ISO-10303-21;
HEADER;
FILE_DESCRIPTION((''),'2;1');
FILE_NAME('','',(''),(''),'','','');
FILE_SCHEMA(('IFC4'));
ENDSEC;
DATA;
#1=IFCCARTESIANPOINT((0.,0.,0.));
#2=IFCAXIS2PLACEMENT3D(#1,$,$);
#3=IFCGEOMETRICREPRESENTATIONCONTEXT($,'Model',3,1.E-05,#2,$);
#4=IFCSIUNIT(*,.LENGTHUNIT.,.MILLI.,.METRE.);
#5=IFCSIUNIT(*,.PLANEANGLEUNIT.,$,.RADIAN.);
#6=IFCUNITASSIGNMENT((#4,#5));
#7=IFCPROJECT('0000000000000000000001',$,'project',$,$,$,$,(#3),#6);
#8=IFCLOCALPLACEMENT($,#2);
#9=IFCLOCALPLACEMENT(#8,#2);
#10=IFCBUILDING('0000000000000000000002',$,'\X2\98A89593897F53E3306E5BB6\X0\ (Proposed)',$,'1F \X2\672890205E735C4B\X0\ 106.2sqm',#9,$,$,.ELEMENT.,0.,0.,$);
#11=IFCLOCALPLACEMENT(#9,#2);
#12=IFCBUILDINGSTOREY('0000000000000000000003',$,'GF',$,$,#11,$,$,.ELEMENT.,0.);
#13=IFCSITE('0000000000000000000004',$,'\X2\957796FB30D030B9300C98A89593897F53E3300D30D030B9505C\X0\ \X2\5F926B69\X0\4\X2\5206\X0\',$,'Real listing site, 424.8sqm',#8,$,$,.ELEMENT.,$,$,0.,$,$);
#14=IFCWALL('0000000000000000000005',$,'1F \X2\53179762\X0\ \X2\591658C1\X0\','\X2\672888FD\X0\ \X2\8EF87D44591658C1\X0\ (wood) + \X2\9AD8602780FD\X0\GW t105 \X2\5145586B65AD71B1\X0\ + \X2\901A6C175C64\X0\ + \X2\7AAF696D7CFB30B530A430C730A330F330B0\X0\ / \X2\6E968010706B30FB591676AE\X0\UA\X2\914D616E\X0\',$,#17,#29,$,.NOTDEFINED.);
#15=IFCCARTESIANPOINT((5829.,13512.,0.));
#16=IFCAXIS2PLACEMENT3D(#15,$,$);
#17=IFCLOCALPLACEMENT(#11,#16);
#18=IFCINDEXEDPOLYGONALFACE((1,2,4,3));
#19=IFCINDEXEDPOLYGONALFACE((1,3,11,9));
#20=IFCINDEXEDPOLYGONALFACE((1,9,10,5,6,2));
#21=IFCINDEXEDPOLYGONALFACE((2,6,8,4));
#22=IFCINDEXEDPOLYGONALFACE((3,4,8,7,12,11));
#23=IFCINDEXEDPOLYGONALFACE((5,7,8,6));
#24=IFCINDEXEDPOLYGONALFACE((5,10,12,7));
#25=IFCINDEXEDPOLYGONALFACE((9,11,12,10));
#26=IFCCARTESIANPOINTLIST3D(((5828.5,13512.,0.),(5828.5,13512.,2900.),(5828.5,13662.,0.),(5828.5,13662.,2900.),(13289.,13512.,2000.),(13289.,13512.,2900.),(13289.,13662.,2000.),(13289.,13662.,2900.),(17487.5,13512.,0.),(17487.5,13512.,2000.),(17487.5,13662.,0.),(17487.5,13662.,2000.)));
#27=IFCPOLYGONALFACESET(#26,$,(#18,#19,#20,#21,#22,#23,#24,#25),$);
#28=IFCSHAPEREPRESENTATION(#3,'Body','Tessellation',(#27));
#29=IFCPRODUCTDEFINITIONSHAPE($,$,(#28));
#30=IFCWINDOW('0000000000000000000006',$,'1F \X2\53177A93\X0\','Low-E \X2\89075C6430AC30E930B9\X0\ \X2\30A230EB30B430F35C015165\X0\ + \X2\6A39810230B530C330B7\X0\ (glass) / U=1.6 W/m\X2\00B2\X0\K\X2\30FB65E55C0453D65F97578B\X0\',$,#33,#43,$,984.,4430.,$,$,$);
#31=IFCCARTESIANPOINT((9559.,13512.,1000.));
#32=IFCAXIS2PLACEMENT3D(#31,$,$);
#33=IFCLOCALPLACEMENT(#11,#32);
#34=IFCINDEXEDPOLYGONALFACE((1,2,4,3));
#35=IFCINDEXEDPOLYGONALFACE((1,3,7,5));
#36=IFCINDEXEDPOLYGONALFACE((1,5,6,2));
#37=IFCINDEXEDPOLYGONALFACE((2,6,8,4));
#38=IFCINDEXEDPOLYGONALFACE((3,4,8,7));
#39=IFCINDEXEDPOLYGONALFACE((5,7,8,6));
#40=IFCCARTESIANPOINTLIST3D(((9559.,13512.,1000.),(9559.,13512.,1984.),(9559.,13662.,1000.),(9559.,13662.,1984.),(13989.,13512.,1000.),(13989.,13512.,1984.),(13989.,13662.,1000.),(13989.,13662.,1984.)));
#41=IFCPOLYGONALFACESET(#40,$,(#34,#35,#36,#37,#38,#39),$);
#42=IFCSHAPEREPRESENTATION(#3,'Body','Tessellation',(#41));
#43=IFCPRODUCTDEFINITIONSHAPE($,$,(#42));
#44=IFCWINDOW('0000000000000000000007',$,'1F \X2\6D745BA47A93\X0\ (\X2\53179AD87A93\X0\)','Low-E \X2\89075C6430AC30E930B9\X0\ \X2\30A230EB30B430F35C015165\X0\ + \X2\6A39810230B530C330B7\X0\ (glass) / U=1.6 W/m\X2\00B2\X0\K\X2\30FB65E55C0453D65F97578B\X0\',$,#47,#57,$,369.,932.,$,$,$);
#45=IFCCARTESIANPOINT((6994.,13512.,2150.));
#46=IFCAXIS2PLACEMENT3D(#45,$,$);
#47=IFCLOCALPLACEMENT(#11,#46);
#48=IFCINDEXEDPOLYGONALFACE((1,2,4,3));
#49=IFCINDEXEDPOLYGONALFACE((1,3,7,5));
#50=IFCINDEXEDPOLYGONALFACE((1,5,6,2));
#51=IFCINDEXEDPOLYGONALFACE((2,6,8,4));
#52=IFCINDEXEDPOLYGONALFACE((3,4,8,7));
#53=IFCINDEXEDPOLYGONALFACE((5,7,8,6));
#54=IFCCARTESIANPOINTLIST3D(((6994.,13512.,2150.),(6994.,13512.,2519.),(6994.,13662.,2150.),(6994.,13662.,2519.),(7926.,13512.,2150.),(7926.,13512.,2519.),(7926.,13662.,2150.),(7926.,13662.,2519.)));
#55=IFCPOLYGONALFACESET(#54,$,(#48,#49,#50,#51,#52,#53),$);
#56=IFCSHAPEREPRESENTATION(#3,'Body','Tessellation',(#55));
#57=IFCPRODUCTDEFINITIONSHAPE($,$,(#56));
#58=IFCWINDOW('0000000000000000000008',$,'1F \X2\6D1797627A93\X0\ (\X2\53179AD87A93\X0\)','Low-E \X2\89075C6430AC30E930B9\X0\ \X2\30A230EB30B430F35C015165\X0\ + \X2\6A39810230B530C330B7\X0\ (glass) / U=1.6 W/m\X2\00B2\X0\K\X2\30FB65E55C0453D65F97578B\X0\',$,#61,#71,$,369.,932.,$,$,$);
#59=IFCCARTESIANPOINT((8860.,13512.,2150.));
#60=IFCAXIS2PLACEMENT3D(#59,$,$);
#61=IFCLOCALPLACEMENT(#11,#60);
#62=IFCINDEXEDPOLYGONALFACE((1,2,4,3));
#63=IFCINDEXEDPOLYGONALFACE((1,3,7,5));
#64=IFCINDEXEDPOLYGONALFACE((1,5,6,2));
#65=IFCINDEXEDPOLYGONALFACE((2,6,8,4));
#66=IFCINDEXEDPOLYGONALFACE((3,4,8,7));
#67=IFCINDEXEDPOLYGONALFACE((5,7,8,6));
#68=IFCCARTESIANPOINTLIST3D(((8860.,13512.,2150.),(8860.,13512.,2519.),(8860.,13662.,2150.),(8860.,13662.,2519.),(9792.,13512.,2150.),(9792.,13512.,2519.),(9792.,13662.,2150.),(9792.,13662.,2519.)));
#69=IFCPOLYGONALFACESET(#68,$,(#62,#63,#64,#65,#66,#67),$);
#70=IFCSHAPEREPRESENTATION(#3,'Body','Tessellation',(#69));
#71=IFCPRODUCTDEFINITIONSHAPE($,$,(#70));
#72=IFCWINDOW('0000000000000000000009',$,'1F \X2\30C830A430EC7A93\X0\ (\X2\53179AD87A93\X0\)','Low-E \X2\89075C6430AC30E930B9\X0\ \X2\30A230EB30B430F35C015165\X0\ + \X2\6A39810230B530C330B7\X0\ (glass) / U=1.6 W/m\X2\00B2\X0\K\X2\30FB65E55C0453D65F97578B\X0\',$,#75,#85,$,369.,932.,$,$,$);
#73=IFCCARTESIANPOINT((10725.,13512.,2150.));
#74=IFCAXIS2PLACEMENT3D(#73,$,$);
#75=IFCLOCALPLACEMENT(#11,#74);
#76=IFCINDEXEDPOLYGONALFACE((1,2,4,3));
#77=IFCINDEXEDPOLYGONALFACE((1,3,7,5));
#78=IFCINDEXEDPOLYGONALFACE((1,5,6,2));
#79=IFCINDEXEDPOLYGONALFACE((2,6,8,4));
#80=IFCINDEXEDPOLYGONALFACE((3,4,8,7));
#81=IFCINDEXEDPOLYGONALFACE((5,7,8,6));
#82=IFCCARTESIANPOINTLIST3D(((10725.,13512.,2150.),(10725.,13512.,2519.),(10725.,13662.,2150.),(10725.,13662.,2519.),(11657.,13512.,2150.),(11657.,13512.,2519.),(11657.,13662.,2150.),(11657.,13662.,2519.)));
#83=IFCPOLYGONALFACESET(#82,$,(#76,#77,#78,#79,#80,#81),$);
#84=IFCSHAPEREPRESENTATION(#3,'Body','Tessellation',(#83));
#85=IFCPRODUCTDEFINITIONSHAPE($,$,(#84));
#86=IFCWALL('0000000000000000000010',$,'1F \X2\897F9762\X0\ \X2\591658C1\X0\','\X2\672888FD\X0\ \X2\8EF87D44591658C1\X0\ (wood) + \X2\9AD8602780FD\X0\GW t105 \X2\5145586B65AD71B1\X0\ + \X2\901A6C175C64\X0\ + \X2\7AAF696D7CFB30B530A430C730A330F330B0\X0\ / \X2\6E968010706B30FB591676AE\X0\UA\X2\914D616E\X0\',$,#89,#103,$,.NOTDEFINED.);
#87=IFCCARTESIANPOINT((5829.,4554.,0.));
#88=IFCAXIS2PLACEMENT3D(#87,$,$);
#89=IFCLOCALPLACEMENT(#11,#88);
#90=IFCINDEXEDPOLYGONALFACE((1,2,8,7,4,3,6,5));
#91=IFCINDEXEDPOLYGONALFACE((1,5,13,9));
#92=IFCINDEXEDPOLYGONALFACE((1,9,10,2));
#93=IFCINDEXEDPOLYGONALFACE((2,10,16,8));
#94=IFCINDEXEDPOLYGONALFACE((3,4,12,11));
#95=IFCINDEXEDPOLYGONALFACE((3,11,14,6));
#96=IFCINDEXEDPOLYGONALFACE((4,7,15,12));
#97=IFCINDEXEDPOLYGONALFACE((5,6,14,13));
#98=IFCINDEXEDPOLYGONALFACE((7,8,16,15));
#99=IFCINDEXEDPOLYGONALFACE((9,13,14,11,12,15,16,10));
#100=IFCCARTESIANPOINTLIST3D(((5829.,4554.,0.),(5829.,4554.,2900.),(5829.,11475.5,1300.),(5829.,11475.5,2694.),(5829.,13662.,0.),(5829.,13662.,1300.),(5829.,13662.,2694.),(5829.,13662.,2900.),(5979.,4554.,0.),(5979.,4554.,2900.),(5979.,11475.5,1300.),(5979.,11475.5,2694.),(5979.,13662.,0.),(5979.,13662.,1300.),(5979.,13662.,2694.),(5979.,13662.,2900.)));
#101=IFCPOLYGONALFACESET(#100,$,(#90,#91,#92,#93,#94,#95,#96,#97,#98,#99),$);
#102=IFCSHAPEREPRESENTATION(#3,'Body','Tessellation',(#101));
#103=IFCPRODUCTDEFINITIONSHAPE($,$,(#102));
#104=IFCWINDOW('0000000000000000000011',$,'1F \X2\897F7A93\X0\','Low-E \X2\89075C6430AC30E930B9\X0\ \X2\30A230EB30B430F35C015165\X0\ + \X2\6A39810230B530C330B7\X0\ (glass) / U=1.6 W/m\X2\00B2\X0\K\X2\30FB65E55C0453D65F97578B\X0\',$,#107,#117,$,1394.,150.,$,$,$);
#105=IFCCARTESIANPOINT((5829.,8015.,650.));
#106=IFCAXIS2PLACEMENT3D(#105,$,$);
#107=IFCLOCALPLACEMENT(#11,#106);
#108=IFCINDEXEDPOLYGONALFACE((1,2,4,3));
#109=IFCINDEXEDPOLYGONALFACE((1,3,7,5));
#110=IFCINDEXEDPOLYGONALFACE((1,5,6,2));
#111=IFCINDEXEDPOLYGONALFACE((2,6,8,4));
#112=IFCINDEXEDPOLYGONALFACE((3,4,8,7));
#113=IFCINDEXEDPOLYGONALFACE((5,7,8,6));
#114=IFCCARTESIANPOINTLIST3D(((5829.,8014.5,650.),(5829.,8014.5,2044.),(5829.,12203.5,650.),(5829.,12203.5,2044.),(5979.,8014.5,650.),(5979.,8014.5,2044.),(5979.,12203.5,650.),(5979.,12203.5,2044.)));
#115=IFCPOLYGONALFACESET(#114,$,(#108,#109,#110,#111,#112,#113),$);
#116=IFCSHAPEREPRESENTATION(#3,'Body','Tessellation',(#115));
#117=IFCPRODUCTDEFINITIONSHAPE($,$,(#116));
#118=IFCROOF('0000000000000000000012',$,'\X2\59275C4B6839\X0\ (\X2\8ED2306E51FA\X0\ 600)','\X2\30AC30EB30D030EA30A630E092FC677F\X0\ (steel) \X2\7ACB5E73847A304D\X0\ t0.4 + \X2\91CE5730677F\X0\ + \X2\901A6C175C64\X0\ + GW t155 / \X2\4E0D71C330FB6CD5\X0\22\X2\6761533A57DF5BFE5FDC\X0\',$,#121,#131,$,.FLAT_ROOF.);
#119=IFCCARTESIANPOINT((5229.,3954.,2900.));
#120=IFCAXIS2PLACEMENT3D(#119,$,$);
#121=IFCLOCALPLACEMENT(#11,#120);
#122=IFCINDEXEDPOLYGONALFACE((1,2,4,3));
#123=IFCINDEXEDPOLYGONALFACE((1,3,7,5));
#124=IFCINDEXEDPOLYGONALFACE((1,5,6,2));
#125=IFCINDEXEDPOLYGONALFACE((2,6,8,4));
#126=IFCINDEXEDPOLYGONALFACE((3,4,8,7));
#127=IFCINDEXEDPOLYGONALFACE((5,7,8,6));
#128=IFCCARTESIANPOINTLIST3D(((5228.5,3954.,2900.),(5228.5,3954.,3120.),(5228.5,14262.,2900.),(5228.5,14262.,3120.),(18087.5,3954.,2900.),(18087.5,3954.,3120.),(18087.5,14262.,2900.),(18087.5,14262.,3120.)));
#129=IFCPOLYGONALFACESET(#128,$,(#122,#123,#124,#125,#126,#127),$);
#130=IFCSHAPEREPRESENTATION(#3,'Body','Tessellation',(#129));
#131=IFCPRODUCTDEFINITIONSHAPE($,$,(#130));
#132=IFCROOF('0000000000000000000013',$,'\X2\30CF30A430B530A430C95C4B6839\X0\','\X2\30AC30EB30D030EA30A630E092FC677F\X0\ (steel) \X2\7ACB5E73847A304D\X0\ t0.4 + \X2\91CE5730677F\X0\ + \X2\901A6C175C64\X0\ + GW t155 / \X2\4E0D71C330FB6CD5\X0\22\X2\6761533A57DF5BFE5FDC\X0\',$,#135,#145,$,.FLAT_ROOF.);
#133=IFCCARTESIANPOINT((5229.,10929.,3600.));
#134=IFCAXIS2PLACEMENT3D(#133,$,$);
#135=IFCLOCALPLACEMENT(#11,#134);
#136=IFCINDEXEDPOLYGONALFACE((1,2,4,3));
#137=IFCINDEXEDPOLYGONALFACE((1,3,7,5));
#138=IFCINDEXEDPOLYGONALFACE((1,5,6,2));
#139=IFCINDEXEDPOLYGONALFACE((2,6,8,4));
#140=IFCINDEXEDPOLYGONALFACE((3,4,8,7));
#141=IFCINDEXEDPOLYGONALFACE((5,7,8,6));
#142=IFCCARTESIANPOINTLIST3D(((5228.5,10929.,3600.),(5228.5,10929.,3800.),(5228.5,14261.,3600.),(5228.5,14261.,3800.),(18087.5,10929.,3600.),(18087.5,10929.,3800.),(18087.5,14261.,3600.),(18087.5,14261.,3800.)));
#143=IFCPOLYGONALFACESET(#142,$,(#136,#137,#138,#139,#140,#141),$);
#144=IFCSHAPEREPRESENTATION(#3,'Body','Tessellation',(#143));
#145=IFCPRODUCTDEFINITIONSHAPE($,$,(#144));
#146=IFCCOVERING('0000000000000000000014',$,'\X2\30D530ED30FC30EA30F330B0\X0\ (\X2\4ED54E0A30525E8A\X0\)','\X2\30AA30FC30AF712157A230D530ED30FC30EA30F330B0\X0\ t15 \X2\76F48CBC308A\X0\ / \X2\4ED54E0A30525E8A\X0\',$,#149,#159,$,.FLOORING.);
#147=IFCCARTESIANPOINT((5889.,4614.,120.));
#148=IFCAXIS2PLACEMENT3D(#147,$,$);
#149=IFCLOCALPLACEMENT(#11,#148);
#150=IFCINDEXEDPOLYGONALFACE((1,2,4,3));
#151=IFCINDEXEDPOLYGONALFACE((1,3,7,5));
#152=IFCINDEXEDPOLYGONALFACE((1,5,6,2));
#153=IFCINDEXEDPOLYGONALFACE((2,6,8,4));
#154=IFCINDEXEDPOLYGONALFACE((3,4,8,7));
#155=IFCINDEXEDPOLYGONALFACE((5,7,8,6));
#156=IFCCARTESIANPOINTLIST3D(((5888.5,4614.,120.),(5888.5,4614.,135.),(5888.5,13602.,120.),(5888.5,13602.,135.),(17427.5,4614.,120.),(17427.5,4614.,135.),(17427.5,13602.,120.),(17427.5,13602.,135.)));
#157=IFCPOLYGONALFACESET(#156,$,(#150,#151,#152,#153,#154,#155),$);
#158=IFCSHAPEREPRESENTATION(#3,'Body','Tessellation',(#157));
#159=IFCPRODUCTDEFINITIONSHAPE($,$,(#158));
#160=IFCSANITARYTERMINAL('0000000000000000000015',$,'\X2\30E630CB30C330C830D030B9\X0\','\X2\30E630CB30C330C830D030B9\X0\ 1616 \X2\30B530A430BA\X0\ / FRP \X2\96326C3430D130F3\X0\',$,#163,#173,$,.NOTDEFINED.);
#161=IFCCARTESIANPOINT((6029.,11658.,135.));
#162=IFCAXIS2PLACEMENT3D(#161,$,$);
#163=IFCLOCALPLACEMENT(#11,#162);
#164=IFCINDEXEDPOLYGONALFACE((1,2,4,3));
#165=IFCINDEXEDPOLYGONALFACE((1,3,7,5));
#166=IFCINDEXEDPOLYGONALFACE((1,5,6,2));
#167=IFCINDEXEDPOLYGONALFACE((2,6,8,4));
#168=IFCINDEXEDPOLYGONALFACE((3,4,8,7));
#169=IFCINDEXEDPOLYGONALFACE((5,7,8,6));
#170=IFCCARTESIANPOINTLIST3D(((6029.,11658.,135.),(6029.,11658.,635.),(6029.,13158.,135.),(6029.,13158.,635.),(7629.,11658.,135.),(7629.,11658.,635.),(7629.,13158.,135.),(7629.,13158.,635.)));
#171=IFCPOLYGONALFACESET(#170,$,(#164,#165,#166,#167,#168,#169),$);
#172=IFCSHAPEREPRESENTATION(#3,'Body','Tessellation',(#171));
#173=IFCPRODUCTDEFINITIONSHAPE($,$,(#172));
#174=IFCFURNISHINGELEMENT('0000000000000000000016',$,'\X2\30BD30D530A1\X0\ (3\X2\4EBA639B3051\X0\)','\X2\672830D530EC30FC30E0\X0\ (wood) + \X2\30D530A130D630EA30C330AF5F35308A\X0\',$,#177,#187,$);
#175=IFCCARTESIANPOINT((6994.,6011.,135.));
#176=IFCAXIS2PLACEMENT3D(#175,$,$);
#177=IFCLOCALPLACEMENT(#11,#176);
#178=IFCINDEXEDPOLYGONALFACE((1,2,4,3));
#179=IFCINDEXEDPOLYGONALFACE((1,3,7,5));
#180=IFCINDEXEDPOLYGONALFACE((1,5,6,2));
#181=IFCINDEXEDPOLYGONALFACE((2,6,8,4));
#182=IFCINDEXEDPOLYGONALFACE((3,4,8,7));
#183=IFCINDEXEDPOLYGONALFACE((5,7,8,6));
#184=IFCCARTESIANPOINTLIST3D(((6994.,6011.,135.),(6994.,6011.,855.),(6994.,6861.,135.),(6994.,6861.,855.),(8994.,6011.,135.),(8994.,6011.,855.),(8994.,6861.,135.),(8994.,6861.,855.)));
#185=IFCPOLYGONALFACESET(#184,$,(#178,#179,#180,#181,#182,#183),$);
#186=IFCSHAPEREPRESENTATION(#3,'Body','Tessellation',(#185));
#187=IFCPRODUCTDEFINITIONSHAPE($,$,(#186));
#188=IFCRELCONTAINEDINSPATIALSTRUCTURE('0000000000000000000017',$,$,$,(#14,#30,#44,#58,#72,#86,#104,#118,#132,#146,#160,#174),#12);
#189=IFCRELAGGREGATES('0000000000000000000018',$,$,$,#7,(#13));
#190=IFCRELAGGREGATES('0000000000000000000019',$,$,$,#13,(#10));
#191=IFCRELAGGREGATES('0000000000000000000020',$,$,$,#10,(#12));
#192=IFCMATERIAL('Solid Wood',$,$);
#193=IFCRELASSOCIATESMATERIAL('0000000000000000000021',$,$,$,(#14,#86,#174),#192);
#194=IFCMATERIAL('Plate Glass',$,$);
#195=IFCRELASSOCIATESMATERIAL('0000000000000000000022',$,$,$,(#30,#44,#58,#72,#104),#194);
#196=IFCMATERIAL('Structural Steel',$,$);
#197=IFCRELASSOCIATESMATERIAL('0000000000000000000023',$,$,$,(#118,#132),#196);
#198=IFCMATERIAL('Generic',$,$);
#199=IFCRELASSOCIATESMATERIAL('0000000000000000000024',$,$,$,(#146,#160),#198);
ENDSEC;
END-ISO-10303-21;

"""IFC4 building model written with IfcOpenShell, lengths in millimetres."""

from ifc_helpers import new_model, si_unit, frame, frame_2d, origin, place, context, project, spatial, rectangle, extrude, material, element, fill, save


model = new_model("IFC4")

# Units and contexts
model_context = context("Model", 3, precision=1e-05, world=origin())
ifc_project = project(units=[si_unit("LENGTHUNIT", "METRE", prefix="MILLI"), si_unit("PLANEANGLEUNIT", "RADIAN")], contexts=[model_context])

# Site, building, storey
site_placement = place(None, origin())
site = spatial("IfcSite", under=ifc_project, at=site_placement, Name="長電バス「風間西口」バス停 徒歩4分", ObjectType="Real listing site, 424.8sqm", CompositionType="ELEMENT", RefElevation=0.0)
building_placement = place(site_placement, origin())
building = spatial("IfcBuilding", under=site, at=building_placement, Name="風間西口の家 (Proposed)", ObjectType="1F 木造平屋 106.2sqm", CompositionType="ELEMENT", ElevationOfRefHeight=0.0, ElevationOfTerrain=0.0)
storey_placement = place(building_placement, origin())
storey = spatial("IfcBuildingStorey", under=building, at=storey_placement, Name="GF", CompositionType="ELEMENT", Elevation=0.0)

# Shared definitions
ifc_material_1 = material(Name="Solid Wood")

# Shared definitions
ifc_material_2 = material(Name="Plate Glass")

# Wall, openings, windows
wall_1_placement = place(storey_placement, frame((5829.0, 13512.0, 0.0)))
wall_1 = element("IfcWall", 1, at=wall_1_placement, inside=storey, material=ifc_material_1, Name="1F 北面 外壁", Description="木製 軸組外壁 (wood) + 高性能GW t105 充填断熱 + 通気層 + 窯業系サイディング / 準耐火・外皮UA配慮", PredefinedType="NOTDEFINED", context=model_context, shape_type="SweptSolid", body=[
    extrude(rectangle(XDim=11659.0, YDim=150.0, at=frame_2d((5829.0, 75.0))), frame((5829.0, 13512.0, 0.0)), (0.0, 0.0, 1.0), 2900.0),
])
opening_1_placement = place(storey_placement, frame((9559.0, 13512.0, 1000.0)))
opening_1 = element("IfcOpeningElement", 2, at=opening_1_placement, cuts=wall_1, PredefinedType="NOTDEFINED", context=model_context, shape_type="SweptSolid", body=[
    extrude(rectangle(XDim=4430.0, YDim=150.0, at=frame_2d((2215.0, 75.0))), frame((9559.0, 13512.0, 1000.0)), (0.0, 0.0, 1.0), 984.0),
])
opening_2_placement = place(storey_placement, frame((6994.0, 13512.0, 2150.0)))
opening_2 = element("IfcOpeningElement", 3, at=opening_2_placement, cuts=wall_1, PredefinedType="NOTDEFINED", context=model_context, shape_type="SweptSolid", body=[
    extrude(rectangle(XDim=932.0, YDim=150.0, at=frame_2d((466.0, 75.0))), frame((6994.0, 13512.0, 2150.0)), (0.0, 0.0, 1.0), 369.0),
])
opening_3_placement = place(storey_placement, frame((8860.0, 13512.0, 2150.0)))
opening_3 = element("IfcOpeningElement", 4, at=opening_3_placement, cuts=wall_1, PredefinedType="NOTDEFINED", context=model_context, shape_type="SweptSolid", body=[
    extrude(rectangle(XDim=932.0, YDim=150.0, at=frame_2d((466.0, 75.0))), frame((8860.0, 13512.0, 2150.0)), (0.0, 0.0, 1.0), 369.0),
])
opening_4_placement = place(storey_placement, frame((10725.0, 13512.0, 2150.0)))
opening_4 = element("IfcOpeningElement", 5, at=opening_4_placement, cuts=wall_1, PredefinedType="NOTDEFINED", context=model_context, shape_type="SweptSolid", body=[
    extrude(rectangle(XDim=932.0, YDim=150.0, at=frame_2d((466.0, 75.0))), frame((10725.0, 13512.0, 2150.0)), (0.0, 0.0, 1.0), 369.0),
])
window_1_placement = place(storey_placement, frame((9559.0, 13512.0, 1000.0)))
window_1 = element("IfcWindow", 6, at=window_1_placement, inside=storey, material=ifc_material_2, Name="1F 北窓", Description="Low-E 複層ガラス アルゴン封入 + 樹脂サッシ (glass) / U=1.6 W/m²K・日射取得型", OverallHeight=984.0, OverallWidth=4430.0, context=model_context, shape_type="SweptSolid", body=[
    extrude(rectangle(XDim=4430.0, YDim=150.0, at=frame_2d((2215.0, 75.0))), frame((9559.0, 13512.0, 1000.0)), (0.0, 0.0, 1.0), 984.0),
])
fill(opening_1, window_1)
window_2_placement = place(storey_placement, frame((6994.0, 13512.0, 2150.0)))
window_2 = element("IfcWindow", 7, at=window_2_placement, inside=storey, material=ifc_material_2, Name="1F 浴室窓 (北高窓)", Description="Low-E 複層ガラス アルゴン封入 + 樹脂サッシ (glass) / U=1.6 W/m²K・日射取得型", OverallHeight=369.0, OverallWidth=932.0, context=model_context, shape_type="SweptSolid", body=[
    extrude(rectangle(XDim=932.0, YDim=150.0, at=frame_2d((466.0, 75.0))), frame((6994.0, 13512.0, 2150.0)), (0.0, 0.0, 1.0), 369.0),
])
fill(opening_2, window_2)
window_3_placement = place(storey_placement, frame((8860.0, 13512.0, 2150.0)))
window_3 = element("IfcWindow", 8, at=window_3_placement, inside=storey, material=ifc_material_2, Name="1F 洗面窓 (北高窓)", Description="Low-E 複層ガラス アルゴン封入 + 樹脂サッシ (glass) / U=1.6 W/m²K・日射取得型", OverallHeight=369.0, OverallWidth=932.0, context=model_context, shape_type="SweptSolid", body=[
    extrude(rectangle(XDim=932.0, YDim=150.0, at=frame_2d((466.0, 75.0))), frame((8860.0, 13512.0, 2150.0)), (0.0, 0.0, 1.0), 369.0),
])
fill(opening_3, window_3)
window_4_placement = place(storey_placement, frame((10725.0, 13512.0, 2150.0)))
window_4 = element("IfcWindow", 9, at=window_4_placement, inside=storey, material=ifc_material_2, Name="1F トイレ窓 (北高窓)", Description="Low-E 複層ガラス アルゴン封入 + 樹脂サッシ (glass) / U=1.6 W/m²K・日射取得型", OverallHeight=369.0, OverallWidth=932.0, context=model_context, shape_type="SweptSolid", body=[
    extrude(rectangle(XDim=932.0, YDim=150.0, at=frame_2d((466.0, 75.0))), frame((10725.0, 13512.0, 2150.0)), (0.0, 0.0, 1.0), 369.0),
])
fill(opening_4, window_4)

# Wall, opening, window
wall_2_placement = place(storey_placement, frame((5829.0, 4554.0, 0.0)))
wall_2 = element("IfcWall", 10, at=wall_2_placement, inside=storey, material=ifc_material_1, Name="1F 西面 外壁", Description="木製 軸組外壁 (wood) + 高性能GW t105 充填断熱 + 通気層 + 窯業系サイディング / 準耐火・外皮UA配慮", PredefinedType="NOTDEFINED", context=model_context, shape_type="SweptSolid", body=[
    extrude(rectangle(XDim=150.0, YDim=9108.0, at=frame_2d((75.0, 4554.0))), frame((5829.0, 4554.0, 0.0)), (0.0, 0.0, 1.0), 2900.0),
])
opening_5_placement = place(storey_placement, frame((5829.0, 8015.0, 650.0)))
opening_5 = element("IfcOpeningElement", 11, at=opening_5_placement, cuts=wall_2, PredefinedType="NOTDEFINED", context=model_context, shape_type="SweptSolid", body=[
    extrude(rectangle(XDim=150.0, YDim=4189.0, at=frame_2d((75.0, 2094.0))), frame((5829.0, 8015.0, 650.0)), (0.0, 0.0, 1.0), 1394.0),
])
window_5_placement = place(storey_placement, frame((5829.0, 8015.0, 650.0)))
window_5 = element("IfcWindow", 12, at=window_5_placement, inside=storey, material=ifc_material_2, Name="1F 西窓", Description="Low-E 複層ガラス アルゴン封入 + 樹脂サッシ (glass) / U=1.6 W/m²K・日射取得型", OverallHeight=1394.0, OverallWidth=150.0, context=model_context, shape_type="SweptSolid", body=[
    extrude(rectangle(XDim=150.0, YDim=4189.0, at=frame_2d((75.0, 2094.0))), frame((5829.0, 8015.0, 650.0)), (0.0, 0.0, 1.0), 1394.0),
])
fill(opening_5, window_5)

# Roofs
ifc_material_3 = material(Name="Structural Steel")
roof_1_placement = place(storey_placement, frame((5229.0, 3954.0, 2900.0)))
element("IfcRoof", 13, at=roof_1_placement, inside=storey, material=ifc_material_3, Name="大屋根 (軒の出 600)", Description="ガルバリウム鋼板 (steel) 立平葺き t0.4 + 野地板 + 通気層 + GW t155 / 不燃・法22条区域対応", PredefinedType="FLAT_ROOF", context=model_context, shape_type="SweptSolid", body=[
    extrude(rectangle(XDim=12859.0, YDim=10308.0, at=frame_2d((6429.0, 5154.0))), frame((5229.0, 3954.0, 2900.0)), (0.0, 0.0, 1.0), 220.0),
])
roof_2_placement = place(storey_placement, frame((5229.0, 10929.0, 3600.0)))
element("IfcRoof", 14, at=roof_2_placement, inside=storey, material=ifc_material_3, Name="ハイサイド屋根", Description="ガルバリウム鋼板 (steel) 立平葺き t0.4 + 野地板 + 通気層 + GW t155 / 不燃・法22条区域対応", PredefinedType="FLAT_ROOF", context=model_context, shape_type="SweptSolid", body=[
    extrude(rectangle(XDim=12859.0, YDim=3332.0, at=frame_2d((6429.0, 1666.0))), frame((5229.0, 10929.0, 3600.0)), (0.0, 0.0, 1.0), 200.0),
])

# Covering
ifc_material_4 = material(Name="Generic")
covering_placement = place(storey_placement, frame((5889.0, 4614.0, 120.0)))
element("IfcCovering", 15, at=covering_placement, inside=storey, material=ifc_material_4, Name="フローリング (仕上げ床)", Description="オーク無垢フローリング t15 直貼り / 仕上げ床", PredefinedType="FLOORING", context=model_context, shape_type="SweptSolid", body=[
    extrude(rectangle(XDim=11539.0, YDim=8988.0, at=frame_2d((5769.0, 4494.0))), frame((5889.0, 4614.0, 120.0)), (0.0, 0.0, 1.0), 15.0),
])

# Sanitary terminal
sanitary_terminal_placement = place(storey_placement, frame((6029.0, 11658.0, 135.0)))
element("IfcSanitaryTerminal", 16, at=sanitary_terminal_placement, inside=storey, material=ifc_material_4, Name="ユニットバス", Description="ユニットバス 1616 サイズ / FRP 防水パン", PredefinedType="NOTDEFINED", context=model_context, shape_type="SweptSolid", body=[
    extrude(rectangle(XDim=1600.0, YDim=1500.0, at=frame_2d((800.0, 750.0))), frame((6029.0, 11658.0, 135.0)), (0.0, 0.0, 1.0), 500.0),
])

# Furnishing element
furnishing_1_placement = place(storey_placement, frame((6994.0, 6011.0, 135.0)))
element("IfcFurnishingElement", 17, at=furnishing_1_placement, inside=storey, material=ifc_material_1, Name="ソファ (3人掛け)", Description="木フレーム (wood) + ファブリック張り", context=model_context, shape_type="SweptSolid", body=[
    extrude(rectangle(XDim=2000.0, YDim=850.0, at=frame_2d((1000.0, 425.0))), frame((6994.0, 6011.0, 135.0)), (0.0, 0.0, 1.0), 720.0),
])

save(model, "model.ifc")
